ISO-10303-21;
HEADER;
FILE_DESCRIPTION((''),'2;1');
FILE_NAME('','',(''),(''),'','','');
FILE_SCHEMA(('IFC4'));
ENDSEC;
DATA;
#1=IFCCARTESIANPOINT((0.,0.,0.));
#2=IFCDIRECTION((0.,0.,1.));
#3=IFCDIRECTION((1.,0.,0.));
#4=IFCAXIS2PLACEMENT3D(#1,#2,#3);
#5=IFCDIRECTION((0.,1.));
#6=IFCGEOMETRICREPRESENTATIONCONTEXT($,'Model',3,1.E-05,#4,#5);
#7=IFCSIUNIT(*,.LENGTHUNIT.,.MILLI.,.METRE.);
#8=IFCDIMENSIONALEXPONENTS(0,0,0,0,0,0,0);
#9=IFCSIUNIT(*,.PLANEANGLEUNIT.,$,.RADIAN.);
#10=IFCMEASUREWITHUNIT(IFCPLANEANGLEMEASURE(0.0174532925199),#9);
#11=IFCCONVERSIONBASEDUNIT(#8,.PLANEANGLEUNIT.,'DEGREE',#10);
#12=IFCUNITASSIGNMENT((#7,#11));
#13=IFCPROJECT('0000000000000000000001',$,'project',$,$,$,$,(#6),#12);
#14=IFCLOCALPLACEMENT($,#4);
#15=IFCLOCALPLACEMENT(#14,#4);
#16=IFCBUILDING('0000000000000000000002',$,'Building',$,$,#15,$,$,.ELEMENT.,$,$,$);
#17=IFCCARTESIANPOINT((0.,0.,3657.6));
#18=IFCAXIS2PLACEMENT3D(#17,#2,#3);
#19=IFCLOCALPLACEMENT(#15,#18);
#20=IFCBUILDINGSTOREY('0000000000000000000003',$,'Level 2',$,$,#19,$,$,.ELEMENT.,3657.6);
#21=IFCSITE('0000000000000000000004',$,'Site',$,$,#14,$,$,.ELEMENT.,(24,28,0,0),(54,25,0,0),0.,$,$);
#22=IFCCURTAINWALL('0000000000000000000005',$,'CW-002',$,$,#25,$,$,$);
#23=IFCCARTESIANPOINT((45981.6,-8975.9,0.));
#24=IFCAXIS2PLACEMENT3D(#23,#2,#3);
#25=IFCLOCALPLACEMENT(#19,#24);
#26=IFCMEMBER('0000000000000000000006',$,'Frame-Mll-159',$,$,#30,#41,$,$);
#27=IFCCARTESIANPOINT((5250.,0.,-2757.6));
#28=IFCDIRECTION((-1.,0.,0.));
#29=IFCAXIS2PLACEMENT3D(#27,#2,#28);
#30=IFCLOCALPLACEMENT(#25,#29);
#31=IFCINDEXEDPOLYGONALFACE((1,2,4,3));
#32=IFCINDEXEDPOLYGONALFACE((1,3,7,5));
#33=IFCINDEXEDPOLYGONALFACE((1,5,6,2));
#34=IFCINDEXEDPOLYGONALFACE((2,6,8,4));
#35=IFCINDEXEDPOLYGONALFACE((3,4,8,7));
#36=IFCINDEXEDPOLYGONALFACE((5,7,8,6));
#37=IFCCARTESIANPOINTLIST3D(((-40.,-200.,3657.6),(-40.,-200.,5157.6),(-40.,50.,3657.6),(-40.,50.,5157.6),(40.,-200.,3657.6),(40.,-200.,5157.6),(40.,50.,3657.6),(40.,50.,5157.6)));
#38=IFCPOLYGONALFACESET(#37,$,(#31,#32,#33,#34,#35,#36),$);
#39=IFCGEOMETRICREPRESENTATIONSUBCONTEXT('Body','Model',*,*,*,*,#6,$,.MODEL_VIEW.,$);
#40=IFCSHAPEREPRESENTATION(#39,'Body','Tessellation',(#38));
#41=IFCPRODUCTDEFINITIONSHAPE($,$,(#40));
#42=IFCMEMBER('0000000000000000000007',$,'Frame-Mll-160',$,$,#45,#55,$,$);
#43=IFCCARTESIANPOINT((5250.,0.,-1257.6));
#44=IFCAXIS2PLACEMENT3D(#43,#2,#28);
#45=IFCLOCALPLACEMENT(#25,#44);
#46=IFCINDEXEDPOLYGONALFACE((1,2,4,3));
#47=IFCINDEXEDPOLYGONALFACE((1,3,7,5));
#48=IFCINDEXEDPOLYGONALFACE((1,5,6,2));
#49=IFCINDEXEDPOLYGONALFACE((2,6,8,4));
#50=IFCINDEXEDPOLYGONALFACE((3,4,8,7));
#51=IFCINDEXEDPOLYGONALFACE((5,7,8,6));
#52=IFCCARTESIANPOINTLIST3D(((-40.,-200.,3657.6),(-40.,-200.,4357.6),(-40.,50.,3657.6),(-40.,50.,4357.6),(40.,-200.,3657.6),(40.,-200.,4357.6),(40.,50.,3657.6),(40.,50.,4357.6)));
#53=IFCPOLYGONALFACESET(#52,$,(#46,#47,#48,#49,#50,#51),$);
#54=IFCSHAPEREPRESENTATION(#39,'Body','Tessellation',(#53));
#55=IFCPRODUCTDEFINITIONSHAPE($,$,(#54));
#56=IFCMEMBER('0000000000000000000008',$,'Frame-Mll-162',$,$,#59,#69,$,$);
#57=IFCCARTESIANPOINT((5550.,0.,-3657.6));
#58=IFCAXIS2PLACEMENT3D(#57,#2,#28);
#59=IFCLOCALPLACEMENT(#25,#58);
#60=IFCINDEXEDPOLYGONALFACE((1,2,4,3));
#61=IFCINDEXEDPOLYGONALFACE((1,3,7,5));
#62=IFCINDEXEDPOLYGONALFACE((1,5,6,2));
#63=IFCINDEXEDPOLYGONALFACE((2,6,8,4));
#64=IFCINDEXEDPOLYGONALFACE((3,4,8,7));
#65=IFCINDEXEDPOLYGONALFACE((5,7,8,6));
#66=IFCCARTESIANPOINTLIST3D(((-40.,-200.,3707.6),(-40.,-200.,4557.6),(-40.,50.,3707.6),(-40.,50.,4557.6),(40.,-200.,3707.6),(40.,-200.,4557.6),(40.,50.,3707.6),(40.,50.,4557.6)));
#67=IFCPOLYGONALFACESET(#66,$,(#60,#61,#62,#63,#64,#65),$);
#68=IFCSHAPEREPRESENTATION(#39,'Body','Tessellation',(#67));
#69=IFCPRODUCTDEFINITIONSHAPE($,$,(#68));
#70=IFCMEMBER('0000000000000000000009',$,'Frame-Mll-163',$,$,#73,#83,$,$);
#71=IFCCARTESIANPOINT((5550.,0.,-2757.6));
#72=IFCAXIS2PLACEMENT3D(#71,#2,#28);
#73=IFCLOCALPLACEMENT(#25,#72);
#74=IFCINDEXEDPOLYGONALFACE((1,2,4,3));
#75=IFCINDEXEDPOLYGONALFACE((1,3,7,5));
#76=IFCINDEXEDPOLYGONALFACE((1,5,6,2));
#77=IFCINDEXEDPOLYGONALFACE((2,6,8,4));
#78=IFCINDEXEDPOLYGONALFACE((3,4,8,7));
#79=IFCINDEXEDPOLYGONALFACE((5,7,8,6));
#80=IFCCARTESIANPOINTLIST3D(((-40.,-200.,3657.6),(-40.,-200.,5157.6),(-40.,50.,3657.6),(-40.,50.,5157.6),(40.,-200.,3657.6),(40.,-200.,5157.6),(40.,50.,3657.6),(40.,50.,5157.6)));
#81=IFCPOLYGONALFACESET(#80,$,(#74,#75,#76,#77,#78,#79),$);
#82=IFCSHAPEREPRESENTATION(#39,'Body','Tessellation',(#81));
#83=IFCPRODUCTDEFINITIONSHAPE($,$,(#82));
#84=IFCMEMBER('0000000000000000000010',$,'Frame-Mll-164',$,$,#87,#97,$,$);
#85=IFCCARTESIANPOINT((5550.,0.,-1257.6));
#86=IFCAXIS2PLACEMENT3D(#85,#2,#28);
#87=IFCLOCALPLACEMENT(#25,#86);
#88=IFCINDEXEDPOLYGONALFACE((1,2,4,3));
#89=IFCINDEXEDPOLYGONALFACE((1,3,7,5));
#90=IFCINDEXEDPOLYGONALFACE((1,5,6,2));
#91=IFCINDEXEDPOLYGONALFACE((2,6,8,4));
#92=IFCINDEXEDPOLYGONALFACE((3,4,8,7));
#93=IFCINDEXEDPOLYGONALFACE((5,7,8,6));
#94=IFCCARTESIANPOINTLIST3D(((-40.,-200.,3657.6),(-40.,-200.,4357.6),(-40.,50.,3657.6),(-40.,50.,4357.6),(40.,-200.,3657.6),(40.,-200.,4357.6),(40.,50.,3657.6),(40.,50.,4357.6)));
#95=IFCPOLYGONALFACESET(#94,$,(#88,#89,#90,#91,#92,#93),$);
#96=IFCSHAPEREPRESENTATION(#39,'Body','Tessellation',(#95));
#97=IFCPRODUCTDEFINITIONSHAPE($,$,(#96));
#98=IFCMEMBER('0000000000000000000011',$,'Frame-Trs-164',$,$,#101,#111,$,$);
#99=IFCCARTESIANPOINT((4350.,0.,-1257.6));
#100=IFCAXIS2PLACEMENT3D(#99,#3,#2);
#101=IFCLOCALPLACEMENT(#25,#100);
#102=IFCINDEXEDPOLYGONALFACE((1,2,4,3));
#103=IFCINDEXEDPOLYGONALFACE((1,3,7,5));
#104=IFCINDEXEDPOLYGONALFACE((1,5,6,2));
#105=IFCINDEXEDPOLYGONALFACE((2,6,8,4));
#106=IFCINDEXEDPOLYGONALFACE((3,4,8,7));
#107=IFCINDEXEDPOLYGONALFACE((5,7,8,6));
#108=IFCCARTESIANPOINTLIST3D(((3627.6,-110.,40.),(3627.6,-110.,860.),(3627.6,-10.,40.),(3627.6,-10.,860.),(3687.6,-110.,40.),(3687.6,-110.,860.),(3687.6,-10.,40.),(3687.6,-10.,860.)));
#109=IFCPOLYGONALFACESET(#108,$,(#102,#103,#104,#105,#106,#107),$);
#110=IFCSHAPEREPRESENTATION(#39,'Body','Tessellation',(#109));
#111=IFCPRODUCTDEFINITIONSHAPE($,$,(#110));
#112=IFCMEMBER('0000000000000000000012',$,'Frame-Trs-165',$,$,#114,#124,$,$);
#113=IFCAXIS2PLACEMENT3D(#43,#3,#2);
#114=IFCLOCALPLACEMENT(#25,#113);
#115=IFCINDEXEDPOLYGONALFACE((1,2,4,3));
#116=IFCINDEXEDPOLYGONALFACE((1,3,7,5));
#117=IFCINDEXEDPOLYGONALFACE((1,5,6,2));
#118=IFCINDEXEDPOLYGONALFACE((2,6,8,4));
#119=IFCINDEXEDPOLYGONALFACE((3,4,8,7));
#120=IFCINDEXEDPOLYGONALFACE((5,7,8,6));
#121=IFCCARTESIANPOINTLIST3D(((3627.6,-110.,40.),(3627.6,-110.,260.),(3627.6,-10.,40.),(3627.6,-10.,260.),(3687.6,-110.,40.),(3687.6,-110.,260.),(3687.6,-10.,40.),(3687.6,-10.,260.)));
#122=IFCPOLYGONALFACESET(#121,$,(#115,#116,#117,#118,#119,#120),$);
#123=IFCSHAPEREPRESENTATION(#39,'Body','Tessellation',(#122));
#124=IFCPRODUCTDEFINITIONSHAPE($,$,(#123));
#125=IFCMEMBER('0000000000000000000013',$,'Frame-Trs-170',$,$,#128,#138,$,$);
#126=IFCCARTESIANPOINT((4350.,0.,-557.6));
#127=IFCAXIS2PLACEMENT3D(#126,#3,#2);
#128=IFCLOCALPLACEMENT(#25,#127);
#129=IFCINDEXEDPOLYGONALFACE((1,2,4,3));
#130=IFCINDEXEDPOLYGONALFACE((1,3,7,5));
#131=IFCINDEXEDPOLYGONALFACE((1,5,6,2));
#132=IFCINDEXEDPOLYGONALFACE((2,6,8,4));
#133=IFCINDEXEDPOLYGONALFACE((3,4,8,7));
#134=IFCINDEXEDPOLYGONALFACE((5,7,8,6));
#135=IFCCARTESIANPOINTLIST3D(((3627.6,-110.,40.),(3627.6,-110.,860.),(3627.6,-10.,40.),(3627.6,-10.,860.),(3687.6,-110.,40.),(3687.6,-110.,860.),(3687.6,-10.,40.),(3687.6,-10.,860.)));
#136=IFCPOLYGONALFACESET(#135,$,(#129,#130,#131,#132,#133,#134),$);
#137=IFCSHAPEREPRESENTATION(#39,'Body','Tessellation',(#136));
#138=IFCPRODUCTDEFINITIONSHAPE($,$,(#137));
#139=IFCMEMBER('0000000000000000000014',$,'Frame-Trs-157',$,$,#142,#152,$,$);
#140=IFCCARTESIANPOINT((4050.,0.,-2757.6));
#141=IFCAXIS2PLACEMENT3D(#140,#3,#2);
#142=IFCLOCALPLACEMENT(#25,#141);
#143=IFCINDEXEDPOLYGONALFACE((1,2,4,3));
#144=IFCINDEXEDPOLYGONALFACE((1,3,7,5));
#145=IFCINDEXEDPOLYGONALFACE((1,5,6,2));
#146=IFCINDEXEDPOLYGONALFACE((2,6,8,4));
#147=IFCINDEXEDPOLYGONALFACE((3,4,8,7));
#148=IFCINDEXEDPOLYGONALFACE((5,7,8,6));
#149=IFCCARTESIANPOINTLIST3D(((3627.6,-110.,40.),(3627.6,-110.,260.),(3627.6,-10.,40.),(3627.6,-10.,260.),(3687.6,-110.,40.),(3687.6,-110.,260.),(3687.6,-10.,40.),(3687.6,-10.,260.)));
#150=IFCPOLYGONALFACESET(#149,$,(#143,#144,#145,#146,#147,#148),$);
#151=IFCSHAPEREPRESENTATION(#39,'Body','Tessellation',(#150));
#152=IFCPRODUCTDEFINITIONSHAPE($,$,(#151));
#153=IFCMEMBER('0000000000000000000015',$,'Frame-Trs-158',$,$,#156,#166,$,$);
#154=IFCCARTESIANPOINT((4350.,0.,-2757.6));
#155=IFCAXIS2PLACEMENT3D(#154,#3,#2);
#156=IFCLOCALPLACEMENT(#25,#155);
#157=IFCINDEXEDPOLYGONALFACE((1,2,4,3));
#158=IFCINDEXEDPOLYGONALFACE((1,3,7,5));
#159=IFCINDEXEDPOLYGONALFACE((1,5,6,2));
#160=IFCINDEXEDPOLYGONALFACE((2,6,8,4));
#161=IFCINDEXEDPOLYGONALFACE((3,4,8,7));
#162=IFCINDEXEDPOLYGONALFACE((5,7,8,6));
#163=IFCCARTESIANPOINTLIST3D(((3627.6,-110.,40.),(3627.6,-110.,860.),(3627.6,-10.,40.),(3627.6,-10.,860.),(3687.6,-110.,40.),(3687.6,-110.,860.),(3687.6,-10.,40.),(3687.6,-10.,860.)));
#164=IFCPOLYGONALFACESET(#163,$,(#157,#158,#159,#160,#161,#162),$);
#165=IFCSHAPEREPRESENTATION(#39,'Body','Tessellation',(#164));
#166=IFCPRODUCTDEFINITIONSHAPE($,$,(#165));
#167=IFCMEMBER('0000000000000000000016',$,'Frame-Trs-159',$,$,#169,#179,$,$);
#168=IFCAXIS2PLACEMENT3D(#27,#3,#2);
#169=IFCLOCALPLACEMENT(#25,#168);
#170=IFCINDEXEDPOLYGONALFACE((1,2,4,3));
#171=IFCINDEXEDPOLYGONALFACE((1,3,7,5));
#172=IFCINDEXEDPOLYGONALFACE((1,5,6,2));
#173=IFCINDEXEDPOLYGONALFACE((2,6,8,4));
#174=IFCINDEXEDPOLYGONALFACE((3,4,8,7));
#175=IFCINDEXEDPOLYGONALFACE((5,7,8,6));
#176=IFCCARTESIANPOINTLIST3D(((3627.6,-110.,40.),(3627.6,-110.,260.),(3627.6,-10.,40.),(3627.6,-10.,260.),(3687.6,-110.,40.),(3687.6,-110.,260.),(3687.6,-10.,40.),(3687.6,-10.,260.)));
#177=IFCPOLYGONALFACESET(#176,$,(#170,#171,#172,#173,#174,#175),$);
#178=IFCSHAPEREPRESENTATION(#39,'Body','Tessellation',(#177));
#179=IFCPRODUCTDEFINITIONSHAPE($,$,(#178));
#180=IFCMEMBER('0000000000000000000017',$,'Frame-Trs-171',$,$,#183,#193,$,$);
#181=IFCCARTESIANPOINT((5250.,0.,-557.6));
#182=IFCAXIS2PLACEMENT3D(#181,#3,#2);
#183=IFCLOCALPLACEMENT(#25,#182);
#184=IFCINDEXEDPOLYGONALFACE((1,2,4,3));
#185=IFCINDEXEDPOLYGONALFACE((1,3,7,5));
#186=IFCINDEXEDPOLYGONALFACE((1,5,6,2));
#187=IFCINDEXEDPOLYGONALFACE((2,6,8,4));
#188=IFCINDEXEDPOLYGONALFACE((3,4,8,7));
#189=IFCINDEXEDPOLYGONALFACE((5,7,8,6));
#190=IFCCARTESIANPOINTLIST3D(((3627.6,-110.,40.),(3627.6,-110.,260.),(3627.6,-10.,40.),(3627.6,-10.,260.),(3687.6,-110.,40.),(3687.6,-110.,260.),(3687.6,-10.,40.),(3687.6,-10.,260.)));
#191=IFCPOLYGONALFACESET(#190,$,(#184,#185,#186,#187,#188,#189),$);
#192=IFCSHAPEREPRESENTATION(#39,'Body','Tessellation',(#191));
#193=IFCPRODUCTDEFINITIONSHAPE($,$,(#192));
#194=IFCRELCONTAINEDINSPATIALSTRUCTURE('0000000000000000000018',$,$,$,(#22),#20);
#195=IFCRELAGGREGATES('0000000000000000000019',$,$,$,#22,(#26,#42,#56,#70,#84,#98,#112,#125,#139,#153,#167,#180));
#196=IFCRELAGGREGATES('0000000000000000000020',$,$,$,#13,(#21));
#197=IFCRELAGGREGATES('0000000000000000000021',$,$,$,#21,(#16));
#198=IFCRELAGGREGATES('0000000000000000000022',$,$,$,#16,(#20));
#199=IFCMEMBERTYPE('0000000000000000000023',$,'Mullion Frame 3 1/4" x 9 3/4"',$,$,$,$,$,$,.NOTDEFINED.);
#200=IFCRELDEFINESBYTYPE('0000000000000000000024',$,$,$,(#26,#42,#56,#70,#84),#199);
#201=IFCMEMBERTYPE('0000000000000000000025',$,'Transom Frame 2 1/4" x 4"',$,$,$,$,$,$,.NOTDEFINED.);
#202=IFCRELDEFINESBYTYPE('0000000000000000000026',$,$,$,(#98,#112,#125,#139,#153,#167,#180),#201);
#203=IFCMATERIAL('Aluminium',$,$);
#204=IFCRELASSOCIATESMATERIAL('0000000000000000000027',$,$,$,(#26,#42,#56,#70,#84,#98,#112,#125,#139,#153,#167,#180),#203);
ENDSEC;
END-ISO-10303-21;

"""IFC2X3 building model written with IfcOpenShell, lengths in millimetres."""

from ifc_helpers import new_model, entity, si_unit, converted_unit, direction, frame, origin_with_axes, place, context, subcontext, project, spatial, polyline, outline, extrude, material, type_object, element, aggregate, save


model = new_model("IFC2X3")

# Units and contexts
model_context = context("Model", 3, precision=1e-05, world=origin_with_axes(), true_north=direction((0.0, 1.0)))
body_context = subcontext(model_context, "Body", "Model", "MODEL_VIEW")
ifc_project = project(units=[si_unit("LENGTHUNIT", "METRE", prefix="MILLI"), converted_unit("PLANEANGLEUNIT", "DEGREE", entity("IfcPlaneAngleMeasure", 0.0174532925199), si_unit("PLANEANGLEUNIT", "RADIAN"), dimensions=[0, 0, 0, 0, 0, 0, 0])], contexts=[model_context])

# Site, building, storey
site_placement = place(None, origin_with_axes())
site = spatial("IfcSite", under=ifc_project, at=site_placement, Name="Site", CompositionType="ELEMENT", RefLatitude=(24, 28, 0, 0), RefLongitude=(54, 25, 0, 0), RefElevation=0.0)
building_placement = place(site_placement, origin_with_axes())
building = spatial("IfcBuilding", under=site, at=building_placement, Name="Building", CompositionType="ELEMENT")
storey_placement = place(building_placement, frame((0.0, 0.0, 3657.6), z_axis=(0.0, 0.0, 1.0), x_axis=(1.0, 0.0, 0.0)))
storey = spatial("IfcBuildingStorey", under=building, at=storey_placement, Name="Level 2", CompositionType="ELEMENT", Elevation=3657.6)

# Curtain wall, members
curtain_wall_placement = place(storey_placement, frame((45981.6, -8975.9, 0.0), z_axis=(0.0, 0.0, 1.0), x_axis=(1.0, 0.0, 0.0)))
curtain_wall = element("IfcCurtainWall", 1, at=curtain_wall_placement, inside=storey, Name="CW-002")
ifc_material_1 = material(Name="Aluminium")
member_type_1 = type_object("IfcMemberType", Name="Mullion Frame 3 1/4\" x 9 3/4\"", PredefinedType="NOTDEFINED")
member_1_placement = place(curtain_wall_placement, frame((5250.0, 0.0, -2757.6), z_axis=(0.0, 0.0, 1.0), x_axis=(-1.0, 0.0, 0.0)))
member_1 = element("IfcMember", 2, at=member_1_placement, type_object=member_type_1, material=ifc_material_1, Name="Frame-Mll-159", context=body_context, shape_type="SweptSolid", body=[
    extrude(outline(polyline([(-40.0, 200.0), (-40.0, -50.0), (40.0, -50.0), (40.0, 200.0), (-40.0, 200.0)])), frame((0.0, 0.0, 3657.6), z_axis=(0.0, 0.0, 1.0), x_axis=(-1.0, 0.0, 0.0)), (0.0, 0.0, 1.0), 1500.0),
])
member_2_placement = place(curtain_wall_placement, frame((5250.0, 0.0, -1257.6), z_axis=(0.0, 0.0, 1.0), x_axis=(-1.0, 0.0, 0.0)))
member_2 = element("IfcMember", 3, at=member_2_placement, type_object=member_type_1, material=ifc_material_1, Name="Frame-Mll-160", context=body_context, shape_type="SweptSolid", body=[
    extrude(outline(polyline([(-40.0, 200.0), (-40.0, -50.0), (40.0, -50.0), (40.0, 200.0), (-40.0, 200.0)])), frame((0.0, 0.0, 3657.6), z_axis=(0.0, 0.0, 1.0), x_axis=(-1.0, 0.0, 0.0)), (0.0, 0.0, 1.0), 700.0),
])
member_3_placement = place(curtain_wall_placement, frame((5550.0, 0.0, -3657.6), z_axis=(0.0, 0.0, 1.0), x_axis=(-1.0, 0.0, 0.0)))
member_3 = element("IfcMember", 4, at=member_3_placement, type_object=member_type_1, material=ifc_material_1, Name="Frame-Mll-162", context=body_context, shape_type="SweptSolid", body=[
    extrude(outline(polyline([(-40.0, 200.0), (-40.0, -50.0), (40.0, -50.0), (40.0, 200.0), (-40.0, 200.0)])), frame((0.0, 0.0, 3707.6), z_axis=(0.0, 0.0, 1.0), x_axis=(-1.0, 0.0, 0.0)), (0.0, 0.0, 1.0), 850.0),
])
member_4_placement = place(curtain_wall_placement, frame((5550.0, 0.0, -2757.6), z_axis=(0.0, 0.0, 1.0), x_axis=(-1.0, 0.0, 0.0)))
member_4 = element("IfcMember", 5, at=member_4_placement, type_object=member_type_1, material=ifc_material_1, Name="Frame-Mll-163", context=body_context, shape_type="SweptSolid", body=[
    extrude(outline(polyline([(-40.0, 200.0), (-40.0, -50.0), (40.0, -50.0), (40.0, 200.0), (-40.0, 200.0)])), frame((0.0, 0.0, 3657.6), z_axis=(0.0, 0.0, 1.0), x_axis=(-1.0, 0.0, 0.0)), (0.0, 0.0, 1.0), 1500.0),
])
member_5_placement = place(curtain_wall_placement, frame((5550.0, 0.0, -1257.6), z_axis=(0.0, 0.0, 1.0), x_axis=(-1.0, 0.0, 0.0)))
member_5 = element("IfcMember", 6, at=member_5_placement, type_object=member_type_1, material=ifc_material_1, Name="Frame-Mll-164", context=body_context, shape_type="SweptSolid", body=[
    extrude(outline(polyline([(-40.0, 200.0), (-40.0, -50.0), (40.0, -50.0), (40.0, 200.0), (-40.0, 200.0)])), frame((0.0, 0.0, 3657.6), z_axis=(0.0, 0.0, 1.0), x_axis=(-1.0, 0.0, 0.0)), (0.0, 0.0, 1.0), 700.0),
])
member_type_2 = type_object("IfcMemberType", Name="Transom Frame 2 1/4\" x 4\"", PredefinedType="NOTDEFINED")
member_6_placement = place(curtain_wall_placement, frame((4350.0, 0.0, -1257.6), z_axis=(1.0, 0.0, 0.0), x_axis=(0.0, 0.0, 1.0)))
member_6 = element("IfcMember", 7, at=member_6_placement, type_object=member_type_2, material=ifc_material_1, Name="Frame-Trs-164", context=body_context, shape_type="SweptSolid", body=[
    extrude(outline(polyline([(-110.0, -3687.6), (-10.0, -3687.6), (-10.0, -3627.6), (-110.0, -3627.6), (-110.0, -3687.6)])), frame((0.0, 0.0, 40.0), z_axis=(0.0, 0.0, 1.0), x_axis=(0.0, 1.0, 0.0)), (0.0, 0.0, 1.0), 820.0),
])
member_7_placement = place(curtain_wall_placement, frame((5250.0, 0.0, -1257.6), z_axis=(1.0, 0.0, 0.0), x_axis=(0.0, 0.0, 1.0)))
member_7 = element("IfcMember", 8, at=member_7_placement, type_object=member_type_2, material=ifc_material_1, Name="Frame-Trs-165", context=body_context, shape_type="SweptSolid", body=[
    extrude(outline(polyline([(-110.0, -3687.6), (-10.0, -3687.6), (-10.0, -3627.6), (-110.0, -3627.6), (-110.0, -3687.6)])), frame((0.0, 0.0, 40.0), z_axis=(0.0, 0.0, 1.0), x_axis=(0.0, 1.0, 0.0)), (0.0, 0.0, 1.0), 220.0),
])
member_8_placement = place(curtain_wall_placement, frame((4350.0, 0.0, -557.6), z_axis=(1.0, 0.0, 0.0), x_axis=(0.0, 0.0, 1.0)))
member_8 = element("IfcMember", 9, at=member_8_placement, type_object=member_type_2, material=ifc_material_1, Name="Frame-Trs-170", context=body_context, shape_type="SweptSolid", body=[
    extrude(outline(polyline([(-110.0, -3687.6), (-10.0, -3687.6), (-10.0, -3627.6), (-110.0, -3627.6), (-110.0, -3687.6)])), frame((0.0, 0.0, 40.0), z_axis=(0.0, 0.0, 1.0), x_axis=(0.0, 1.0, 0.0)), (0.0, 0.0, 1.0), 820.0),
])
member_9_placement = place(curtain_wall_placement, frame((4050.0, 0.0, -2757.6), z_axis=(1.0, 0.0, 0.0), x_axis=(0.0, 0.0, 1.0)))
member_9 = element("IfcMember", 10, at=member_9_placement, type_object=member_type_2, material=ifc_material_1, Name="Frame-Trs-157", context=body_context, shape_type="SweptSolid", body=[
    extrude(outline(polyline([(-110.0, -3687.6), (-10.0, -3687.6), (-10.0, -3627.6), (-110.0, -3627.6), (-110.0, -3687.6)])), frame((0.0, 0.0, 40.0), z_axis=(0.0, 0.0, 1.0), x_axis=(0.0, 1.0, 0.0)), (0.0, 0.0, 1.0), 220.0),
])
member_10_placement = place(curtain_wall_placement, frame((4350.0, 0.0, -2757.6), z_axis=(1.0, 0.0, 0.0), x_axis=(0.0, 0.0, 1.0)))
member_10 = element("IfcMember", 11, at=member_10_placement, type_object=member_type_2, material=ifc_material_1, Name="Frame-Trs-158", context=body_context, shape_type="SweptSolid", body=[
    extrude(outline(polyline([(-110.0, -3687.6), (-10.0, -3687.6), (-10.0, -3627.6), (-110.0, -3627.6), (-110.0, -3687.6)])), frame((0.0, 0.0, 40.0), z_axis=(0.0, 0.0, 1.0), x_axis=(0.0, 1.0, 0.0)), (0.0, 0.0, 1.0), 820.0),
])
member_11_placement = place(curtain_wall_placement, frame((5250.0, 0.0, -2757.6), z_axis=(1.0, 0.0, 0.0), x_axis=(0.0, 0.0, 1.0)))
member_11 = element("IfcMember", 12, at=member_11_placement, type_object=member_type_2, material=ifc_material_1, Name="Frame-Trs-159", context=body_context, shape_type="SweptSolid", body=[
    extrude(outline(polyline([(-110.0, -3687.6), (-10.0, -3687.6), (-10.0, -3627.6), (-110.0, -3627.6), (-110.0, -3687.6)])), frame((0.0, 0.0, 40.0), z_axis=(0.0, 0.0, 1.0), x_axis=(0.0, 1.0, 0.0)), (0.0, 0.0, 1.0), 220.0),
])
member_12_placement = place(curtain_wall_placement, frame((5250.0, 0.0, -557.6), z_axis=(1.0, 0.0, 0.0), x_axis=(0.0, 0.0, 1.0)))
member_12 = element("IfcMember", 13, at=member_12_placement, type_object=member_type_2, material=ifc_material_1, Name="Frame-Trs-171", context=body_context, shape_type="SweptSolid", body=[
    extrude(outline(polyline([(-110.0, -3687.6), (-10.0, -3687.6), (-10.0, -3627.6), (-110.0, -3627.6), (-110.0, -3687.6)])), frame((0.0, 0.0, 40.0), z_axis=(0.0, 0.0, 1.0), x_axis=(0.0, 1.0, 0.0)), (0.0, 0.0, 1.0), 220.0),
])
aggregate(curtain_wall, [member_1, member_2, member_3, member_4, member_5, member_6, member_7, member_8, member_9, member_10, member_11, member_12])

save(model, "model.ifc")
